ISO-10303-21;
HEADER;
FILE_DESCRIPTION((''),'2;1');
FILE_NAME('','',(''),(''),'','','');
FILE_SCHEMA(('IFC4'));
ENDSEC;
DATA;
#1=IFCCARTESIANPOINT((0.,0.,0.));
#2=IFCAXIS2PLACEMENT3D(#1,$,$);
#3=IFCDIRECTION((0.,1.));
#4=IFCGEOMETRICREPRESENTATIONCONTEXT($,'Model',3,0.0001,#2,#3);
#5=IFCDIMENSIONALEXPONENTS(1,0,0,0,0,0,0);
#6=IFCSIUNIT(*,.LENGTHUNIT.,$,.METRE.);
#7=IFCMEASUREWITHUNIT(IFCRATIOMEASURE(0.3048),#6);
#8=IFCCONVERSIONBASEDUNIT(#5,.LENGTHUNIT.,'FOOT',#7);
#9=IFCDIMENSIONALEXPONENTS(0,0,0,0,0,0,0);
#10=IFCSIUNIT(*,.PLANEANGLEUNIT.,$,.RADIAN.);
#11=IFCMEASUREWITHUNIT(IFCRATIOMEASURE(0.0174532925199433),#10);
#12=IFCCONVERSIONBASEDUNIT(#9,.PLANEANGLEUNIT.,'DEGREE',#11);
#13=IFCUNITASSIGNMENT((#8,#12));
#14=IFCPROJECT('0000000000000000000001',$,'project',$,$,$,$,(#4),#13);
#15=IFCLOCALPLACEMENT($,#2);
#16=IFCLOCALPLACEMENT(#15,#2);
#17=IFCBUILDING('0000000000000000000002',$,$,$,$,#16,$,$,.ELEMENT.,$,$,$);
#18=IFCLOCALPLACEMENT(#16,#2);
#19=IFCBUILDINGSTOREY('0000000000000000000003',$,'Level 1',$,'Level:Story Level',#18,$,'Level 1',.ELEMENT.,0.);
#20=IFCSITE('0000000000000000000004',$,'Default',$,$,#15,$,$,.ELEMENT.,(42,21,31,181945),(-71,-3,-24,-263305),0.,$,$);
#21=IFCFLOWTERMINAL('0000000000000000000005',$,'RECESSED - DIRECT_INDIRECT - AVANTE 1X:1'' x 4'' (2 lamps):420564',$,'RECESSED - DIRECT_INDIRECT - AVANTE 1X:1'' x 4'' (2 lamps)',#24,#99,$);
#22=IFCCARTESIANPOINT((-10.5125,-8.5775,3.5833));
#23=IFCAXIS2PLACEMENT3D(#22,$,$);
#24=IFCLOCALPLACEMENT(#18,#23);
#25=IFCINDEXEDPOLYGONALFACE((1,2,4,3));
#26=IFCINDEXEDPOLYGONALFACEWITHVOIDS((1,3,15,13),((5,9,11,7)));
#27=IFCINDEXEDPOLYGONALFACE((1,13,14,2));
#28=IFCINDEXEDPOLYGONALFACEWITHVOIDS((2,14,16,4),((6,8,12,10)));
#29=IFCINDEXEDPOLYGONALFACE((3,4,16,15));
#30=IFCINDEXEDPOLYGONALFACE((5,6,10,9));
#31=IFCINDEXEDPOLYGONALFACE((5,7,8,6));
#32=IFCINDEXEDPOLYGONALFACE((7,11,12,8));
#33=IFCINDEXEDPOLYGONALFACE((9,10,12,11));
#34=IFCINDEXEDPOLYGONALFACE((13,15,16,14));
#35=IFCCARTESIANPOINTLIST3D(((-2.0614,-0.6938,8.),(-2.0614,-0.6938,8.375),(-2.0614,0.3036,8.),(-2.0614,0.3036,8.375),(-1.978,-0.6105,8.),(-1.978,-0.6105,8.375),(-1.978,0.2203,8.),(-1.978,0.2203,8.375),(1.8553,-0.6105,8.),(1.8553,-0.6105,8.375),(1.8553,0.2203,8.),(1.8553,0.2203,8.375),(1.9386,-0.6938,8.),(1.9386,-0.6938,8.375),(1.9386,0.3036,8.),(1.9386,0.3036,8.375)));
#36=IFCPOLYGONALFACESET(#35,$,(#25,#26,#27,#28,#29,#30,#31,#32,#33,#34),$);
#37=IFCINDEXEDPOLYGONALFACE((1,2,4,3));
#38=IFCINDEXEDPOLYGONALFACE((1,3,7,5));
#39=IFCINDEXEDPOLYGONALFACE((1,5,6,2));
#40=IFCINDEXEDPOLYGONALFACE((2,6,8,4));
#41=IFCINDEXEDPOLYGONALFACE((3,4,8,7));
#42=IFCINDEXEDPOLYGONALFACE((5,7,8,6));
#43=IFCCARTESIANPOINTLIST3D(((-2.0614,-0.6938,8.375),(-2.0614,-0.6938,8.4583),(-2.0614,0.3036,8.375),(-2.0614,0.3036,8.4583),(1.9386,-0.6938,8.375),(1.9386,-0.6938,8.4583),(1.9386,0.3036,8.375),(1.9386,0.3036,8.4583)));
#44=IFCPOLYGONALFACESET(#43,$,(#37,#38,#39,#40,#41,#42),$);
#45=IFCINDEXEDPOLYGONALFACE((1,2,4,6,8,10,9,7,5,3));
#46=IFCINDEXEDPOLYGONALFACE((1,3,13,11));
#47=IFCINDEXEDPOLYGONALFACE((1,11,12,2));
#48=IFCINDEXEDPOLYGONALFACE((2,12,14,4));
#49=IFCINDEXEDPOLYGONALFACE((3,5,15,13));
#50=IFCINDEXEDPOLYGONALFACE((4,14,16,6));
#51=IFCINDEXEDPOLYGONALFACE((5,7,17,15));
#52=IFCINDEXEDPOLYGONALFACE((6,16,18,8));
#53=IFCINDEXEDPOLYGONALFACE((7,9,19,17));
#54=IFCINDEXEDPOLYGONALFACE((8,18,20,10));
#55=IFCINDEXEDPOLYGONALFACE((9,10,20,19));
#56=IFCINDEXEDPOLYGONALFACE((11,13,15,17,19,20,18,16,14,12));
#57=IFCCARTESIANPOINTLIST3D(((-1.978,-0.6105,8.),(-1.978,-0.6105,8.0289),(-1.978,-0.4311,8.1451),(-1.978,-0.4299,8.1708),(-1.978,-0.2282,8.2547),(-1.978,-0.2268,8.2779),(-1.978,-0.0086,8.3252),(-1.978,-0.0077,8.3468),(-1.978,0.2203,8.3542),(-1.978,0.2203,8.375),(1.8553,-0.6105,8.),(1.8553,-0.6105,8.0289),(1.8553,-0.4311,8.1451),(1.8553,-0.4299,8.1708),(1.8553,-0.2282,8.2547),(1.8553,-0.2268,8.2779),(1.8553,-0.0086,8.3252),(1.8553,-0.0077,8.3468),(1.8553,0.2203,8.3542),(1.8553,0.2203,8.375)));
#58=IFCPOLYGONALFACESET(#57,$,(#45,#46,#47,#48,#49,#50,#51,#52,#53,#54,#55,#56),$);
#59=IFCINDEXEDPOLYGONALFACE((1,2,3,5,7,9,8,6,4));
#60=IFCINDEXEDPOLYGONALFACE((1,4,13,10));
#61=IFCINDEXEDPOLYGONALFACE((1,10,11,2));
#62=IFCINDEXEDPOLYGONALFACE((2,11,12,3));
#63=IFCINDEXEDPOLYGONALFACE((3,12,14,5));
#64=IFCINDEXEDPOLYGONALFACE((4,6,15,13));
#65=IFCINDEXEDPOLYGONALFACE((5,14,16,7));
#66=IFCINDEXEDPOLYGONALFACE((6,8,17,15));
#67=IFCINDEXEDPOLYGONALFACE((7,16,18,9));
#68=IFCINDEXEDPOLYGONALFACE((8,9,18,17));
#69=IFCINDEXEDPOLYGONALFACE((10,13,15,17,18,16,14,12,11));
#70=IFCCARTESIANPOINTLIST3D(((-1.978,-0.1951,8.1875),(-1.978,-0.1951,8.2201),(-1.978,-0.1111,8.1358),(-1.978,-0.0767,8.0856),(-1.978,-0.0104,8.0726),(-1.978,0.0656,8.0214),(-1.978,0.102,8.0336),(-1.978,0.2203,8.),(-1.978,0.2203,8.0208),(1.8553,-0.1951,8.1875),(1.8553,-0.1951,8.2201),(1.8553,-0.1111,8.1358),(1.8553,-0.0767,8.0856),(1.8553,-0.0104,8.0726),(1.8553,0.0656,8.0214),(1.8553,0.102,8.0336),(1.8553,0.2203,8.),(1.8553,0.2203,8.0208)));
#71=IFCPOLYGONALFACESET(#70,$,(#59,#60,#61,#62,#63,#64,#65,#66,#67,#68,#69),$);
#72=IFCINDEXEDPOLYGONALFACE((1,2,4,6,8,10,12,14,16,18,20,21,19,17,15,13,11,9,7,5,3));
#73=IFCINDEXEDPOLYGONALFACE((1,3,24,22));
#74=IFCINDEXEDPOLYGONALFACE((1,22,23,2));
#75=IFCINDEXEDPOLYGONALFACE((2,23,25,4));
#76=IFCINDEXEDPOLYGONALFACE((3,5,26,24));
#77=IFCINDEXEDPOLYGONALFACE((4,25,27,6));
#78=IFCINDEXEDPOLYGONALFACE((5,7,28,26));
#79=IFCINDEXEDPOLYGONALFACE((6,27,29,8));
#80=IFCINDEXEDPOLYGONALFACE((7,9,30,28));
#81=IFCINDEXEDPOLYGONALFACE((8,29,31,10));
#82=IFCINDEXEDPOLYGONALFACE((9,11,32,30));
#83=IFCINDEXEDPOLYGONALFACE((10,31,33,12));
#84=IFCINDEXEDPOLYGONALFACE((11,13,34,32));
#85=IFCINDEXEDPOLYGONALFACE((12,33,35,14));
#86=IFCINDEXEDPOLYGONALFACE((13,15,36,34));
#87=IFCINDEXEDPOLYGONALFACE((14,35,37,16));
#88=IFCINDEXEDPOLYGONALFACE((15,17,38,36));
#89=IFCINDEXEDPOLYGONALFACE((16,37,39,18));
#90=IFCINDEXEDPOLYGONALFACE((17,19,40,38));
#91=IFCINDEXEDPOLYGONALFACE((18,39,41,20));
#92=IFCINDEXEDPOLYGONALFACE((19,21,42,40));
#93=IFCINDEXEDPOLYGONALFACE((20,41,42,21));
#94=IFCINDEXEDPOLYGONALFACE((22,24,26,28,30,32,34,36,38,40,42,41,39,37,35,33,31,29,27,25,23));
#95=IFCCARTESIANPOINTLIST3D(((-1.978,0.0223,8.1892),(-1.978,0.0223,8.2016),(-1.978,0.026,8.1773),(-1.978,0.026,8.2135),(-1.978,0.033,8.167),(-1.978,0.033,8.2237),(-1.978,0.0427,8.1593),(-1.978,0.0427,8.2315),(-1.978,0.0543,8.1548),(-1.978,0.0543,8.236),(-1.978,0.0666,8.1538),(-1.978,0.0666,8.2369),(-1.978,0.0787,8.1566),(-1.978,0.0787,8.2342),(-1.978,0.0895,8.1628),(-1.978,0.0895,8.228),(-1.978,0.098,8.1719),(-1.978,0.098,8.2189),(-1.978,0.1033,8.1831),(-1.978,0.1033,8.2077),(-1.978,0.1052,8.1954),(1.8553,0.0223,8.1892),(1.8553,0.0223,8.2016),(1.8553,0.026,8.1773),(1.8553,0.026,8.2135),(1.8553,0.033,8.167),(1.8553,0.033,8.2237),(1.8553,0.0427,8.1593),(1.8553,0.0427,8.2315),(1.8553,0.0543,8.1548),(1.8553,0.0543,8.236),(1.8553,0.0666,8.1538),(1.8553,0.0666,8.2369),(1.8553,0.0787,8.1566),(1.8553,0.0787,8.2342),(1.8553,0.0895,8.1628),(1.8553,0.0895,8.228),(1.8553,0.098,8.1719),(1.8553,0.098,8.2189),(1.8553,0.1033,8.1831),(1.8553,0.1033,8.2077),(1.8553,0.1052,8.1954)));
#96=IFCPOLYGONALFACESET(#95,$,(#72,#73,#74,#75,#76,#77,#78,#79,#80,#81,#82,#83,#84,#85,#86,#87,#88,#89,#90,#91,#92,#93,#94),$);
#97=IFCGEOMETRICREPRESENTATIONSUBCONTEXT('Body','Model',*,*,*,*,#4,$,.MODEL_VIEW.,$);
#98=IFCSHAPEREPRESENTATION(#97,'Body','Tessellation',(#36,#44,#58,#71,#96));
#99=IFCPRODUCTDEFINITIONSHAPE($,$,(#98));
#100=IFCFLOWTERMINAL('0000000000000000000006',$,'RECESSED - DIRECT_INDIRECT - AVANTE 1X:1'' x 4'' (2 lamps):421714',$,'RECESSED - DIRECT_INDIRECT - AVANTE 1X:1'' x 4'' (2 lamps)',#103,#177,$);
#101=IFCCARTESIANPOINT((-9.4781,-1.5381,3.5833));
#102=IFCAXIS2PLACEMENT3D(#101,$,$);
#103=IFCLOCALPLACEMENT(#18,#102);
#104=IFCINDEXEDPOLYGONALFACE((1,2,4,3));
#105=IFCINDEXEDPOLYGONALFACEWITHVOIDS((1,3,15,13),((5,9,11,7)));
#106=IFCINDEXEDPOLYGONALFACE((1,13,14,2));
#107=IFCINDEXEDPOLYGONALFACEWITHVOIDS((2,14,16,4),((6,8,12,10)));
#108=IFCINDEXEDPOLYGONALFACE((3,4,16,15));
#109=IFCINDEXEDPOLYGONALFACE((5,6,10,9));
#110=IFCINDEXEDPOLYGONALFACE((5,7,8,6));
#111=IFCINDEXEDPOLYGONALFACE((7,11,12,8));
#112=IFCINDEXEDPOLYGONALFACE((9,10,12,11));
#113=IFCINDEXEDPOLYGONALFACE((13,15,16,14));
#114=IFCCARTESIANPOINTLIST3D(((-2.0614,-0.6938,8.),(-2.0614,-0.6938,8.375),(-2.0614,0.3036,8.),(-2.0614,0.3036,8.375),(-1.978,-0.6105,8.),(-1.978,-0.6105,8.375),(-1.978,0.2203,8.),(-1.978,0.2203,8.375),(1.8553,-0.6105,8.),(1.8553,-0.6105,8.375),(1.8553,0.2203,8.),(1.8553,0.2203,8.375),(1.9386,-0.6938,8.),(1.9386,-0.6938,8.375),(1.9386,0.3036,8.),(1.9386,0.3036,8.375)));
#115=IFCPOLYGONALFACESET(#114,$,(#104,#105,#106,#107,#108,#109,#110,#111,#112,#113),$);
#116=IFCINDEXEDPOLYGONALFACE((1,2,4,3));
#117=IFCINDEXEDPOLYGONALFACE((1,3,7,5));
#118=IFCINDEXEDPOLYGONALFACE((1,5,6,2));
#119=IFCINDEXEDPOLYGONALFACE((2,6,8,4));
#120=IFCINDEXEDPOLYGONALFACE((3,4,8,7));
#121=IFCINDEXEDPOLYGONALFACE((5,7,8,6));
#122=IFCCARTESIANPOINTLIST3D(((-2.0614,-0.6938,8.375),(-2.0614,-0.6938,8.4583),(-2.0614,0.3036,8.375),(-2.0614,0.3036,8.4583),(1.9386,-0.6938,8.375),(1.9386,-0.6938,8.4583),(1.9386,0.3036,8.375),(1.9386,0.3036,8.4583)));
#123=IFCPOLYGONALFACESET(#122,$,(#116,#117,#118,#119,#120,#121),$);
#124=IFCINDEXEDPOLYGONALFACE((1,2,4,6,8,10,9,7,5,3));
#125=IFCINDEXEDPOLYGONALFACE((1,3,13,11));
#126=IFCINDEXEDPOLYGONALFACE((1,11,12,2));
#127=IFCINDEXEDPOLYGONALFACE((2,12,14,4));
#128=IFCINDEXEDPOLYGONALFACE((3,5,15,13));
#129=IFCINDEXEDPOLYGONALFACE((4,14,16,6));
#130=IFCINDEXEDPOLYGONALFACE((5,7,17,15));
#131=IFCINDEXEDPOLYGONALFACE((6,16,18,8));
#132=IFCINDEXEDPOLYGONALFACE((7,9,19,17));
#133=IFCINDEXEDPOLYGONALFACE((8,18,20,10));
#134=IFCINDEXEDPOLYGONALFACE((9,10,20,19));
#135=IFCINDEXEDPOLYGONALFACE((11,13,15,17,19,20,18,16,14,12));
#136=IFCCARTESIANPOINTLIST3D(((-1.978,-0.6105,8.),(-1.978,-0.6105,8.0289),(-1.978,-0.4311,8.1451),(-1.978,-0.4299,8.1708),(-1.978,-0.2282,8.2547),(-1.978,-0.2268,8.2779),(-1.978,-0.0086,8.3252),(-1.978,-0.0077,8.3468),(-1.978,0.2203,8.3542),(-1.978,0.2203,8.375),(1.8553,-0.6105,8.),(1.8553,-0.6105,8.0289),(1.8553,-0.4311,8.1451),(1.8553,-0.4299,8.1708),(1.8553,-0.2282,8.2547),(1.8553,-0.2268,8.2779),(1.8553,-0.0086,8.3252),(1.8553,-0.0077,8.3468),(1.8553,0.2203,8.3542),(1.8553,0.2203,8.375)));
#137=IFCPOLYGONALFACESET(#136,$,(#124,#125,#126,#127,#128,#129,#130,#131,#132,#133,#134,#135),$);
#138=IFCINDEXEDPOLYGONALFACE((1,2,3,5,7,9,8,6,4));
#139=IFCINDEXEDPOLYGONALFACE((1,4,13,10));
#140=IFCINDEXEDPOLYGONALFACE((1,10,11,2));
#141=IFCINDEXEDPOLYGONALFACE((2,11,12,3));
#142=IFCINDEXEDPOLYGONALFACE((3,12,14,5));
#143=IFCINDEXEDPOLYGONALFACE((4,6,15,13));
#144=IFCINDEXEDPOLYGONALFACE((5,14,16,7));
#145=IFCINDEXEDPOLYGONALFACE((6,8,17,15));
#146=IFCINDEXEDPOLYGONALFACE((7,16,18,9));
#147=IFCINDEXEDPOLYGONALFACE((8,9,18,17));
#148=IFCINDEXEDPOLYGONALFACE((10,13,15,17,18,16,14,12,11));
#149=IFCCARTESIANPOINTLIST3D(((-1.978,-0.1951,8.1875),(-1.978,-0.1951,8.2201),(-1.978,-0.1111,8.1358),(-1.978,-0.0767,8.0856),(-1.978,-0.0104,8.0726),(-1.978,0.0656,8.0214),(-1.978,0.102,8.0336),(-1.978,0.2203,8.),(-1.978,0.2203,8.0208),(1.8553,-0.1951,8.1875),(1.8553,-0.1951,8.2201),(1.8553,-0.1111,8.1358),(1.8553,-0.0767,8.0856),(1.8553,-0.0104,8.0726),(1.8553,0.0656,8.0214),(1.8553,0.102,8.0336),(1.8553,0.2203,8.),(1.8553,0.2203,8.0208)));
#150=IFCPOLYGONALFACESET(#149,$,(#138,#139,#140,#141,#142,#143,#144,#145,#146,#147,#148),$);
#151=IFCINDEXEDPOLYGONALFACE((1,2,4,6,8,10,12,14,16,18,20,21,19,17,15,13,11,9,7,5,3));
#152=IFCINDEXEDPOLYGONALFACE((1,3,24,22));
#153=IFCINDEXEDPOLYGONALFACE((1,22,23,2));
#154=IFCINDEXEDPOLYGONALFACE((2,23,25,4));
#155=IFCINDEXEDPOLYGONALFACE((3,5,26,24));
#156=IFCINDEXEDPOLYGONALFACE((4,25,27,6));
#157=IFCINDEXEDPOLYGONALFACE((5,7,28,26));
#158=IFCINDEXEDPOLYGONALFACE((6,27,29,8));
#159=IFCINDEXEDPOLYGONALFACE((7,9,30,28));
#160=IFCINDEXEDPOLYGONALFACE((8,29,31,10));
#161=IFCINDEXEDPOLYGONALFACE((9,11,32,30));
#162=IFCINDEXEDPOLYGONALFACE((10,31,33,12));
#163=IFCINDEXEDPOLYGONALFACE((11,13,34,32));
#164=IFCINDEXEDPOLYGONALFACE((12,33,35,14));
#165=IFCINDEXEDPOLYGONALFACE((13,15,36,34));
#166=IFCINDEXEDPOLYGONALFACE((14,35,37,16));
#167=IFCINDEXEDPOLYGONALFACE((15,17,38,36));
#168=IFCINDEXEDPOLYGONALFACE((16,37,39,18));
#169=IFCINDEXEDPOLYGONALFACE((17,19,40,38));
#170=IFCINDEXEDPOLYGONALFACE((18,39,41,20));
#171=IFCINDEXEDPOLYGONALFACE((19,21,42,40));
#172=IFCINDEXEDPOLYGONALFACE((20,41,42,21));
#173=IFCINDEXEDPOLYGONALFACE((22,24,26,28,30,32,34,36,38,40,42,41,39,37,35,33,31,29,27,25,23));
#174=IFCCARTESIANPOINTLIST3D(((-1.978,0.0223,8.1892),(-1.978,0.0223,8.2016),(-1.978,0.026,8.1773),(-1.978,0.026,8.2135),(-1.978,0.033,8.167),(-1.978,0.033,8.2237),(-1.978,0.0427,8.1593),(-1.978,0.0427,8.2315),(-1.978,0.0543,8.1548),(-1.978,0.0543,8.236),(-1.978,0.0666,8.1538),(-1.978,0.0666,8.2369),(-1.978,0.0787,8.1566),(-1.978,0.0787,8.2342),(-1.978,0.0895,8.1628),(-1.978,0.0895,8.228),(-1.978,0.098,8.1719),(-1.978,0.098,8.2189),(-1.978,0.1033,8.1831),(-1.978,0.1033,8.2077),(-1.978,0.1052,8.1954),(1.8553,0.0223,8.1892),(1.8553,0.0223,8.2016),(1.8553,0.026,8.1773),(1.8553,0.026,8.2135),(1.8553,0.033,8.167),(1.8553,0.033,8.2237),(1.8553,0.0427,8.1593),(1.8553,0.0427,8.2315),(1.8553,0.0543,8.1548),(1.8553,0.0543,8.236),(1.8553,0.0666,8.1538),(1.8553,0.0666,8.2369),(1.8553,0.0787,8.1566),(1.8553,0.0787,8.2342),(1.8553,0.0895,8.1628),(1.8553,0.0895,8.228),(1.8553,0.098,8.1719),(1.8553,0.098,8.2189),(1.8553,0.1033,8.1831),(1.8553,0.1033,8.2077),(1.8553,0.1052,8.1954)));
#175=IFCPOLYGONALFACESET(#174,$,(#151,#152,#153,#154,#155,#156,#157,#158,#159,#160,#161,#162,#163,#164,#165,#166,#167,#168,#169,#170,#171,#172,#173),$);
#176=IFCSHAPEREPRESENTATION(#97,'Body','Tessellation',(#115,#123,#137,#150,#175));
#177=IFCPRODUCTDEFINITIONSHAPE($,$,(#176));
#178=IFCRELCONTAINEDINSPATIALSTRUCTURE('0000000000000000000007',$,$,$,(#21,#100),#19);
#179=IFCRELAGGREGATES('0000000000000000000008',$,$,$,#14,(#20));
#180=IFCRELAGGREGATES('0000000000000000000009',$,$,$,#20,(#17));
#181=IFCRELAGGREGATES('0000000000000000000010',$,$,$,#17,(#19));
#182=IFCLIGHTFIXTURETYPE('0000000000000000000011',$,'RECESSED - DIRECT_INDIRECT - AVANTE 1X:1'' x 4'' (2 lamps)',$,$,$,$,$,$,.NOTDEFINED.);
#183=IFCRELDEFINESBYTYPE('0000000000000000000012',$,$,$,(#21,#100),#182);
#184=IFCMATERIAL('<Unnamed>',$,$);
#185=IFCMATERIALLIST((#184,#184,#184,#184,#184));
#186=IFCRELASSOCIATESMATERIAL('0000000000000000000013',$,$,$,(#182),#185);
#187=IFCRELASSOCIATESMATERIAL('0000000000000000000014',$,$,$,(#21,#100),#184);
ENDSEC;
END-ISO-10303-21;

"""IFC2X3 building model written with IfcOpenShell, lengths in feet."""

from ifc_helpers import new_model, entity, si_unit, converted_unit, direction, frame, frame_2d, origin, origin_2d_with_axis, place, context, subcontext, project, spatial, polyline, circle_curve, parameter, trimmed, segment, composite_curve, rectangle, circle, outline, extrude, source, transform, mapped, material, material_list, type_object, type_shapes, element, save


model = new_model("IFC2X3")

# Units and contexts
model_context = context("Model", 3, precision=0.0001, world=origin(), true_north=direction((0.0, 1.0)))
body_context = subcontext(model_context, "Body", "Model", "MODEL_VIEW")
ifc_project = project(units=[converted_unit("LENGTHUNIT", "FOOT", entity("IfcRatioMeasure", 0.3048), si_unit("LENGTHUNIT", "METRE"), dimensions=[1, 0, 0, 0, 0, 0, 0]), converted_unit("PLANEANGLEUNIT", "DEGREE", entity("IfcRatioMeasure", 0.0174532925199433), si_unit("PLANEANGLEUNIT", "RADIAN"), dimensions=[0, 0, 0, 0, 0, 0, 0])], contexts=[model_context])

# Site, building, storey
site_placement = place(None, origin())
site = spatial("IfcSite", under=ifc_project, at=site_placement, Name="Default", CompositionType="ELEMENT", RefLatitude=(42, 21, 31, 181945), RefLongitude=(-71, -3, -24, -263305), RefElevation=0.0)
building_placement = place(site_placement, origin())
building = spatial("IfcBuilding", under=site, at=building_placement, CompositionType="ELEMENT")
storey_placement = place(building_placement, origin())
storey = spatial("IfcBuildingStorey", under=building, at=storey_placement, Name="Level 1", ObjectType="Level:Story Level", LongName="Level 1", CompositionType="ELEMENT", Elevation=0.0)

# Flow terminals
ifc_material_1 = material(Name="<Unnamed>")
ifc_material_list_1 = material_list([ifc_material_1, ifc_material_1, ifc_material_1, ifc_material_1, ifc_material_1])
light_fixture_type = type_object("IfcLightFixtureType", Name="RECESSED - DIRECT_INDIRECT - AVANTE 1X:1' x 4' (2 lamps)", PredefinedType="NOTDEFINED", material=ifc_material_list_1)
shared_shape_1 = source(origin(), body_context, "Body", "SweptSolid", [
    extrude(outline(polyline([(-2.0, -0.4987), (2.0, -0.4987), (2.0, 0.4987), (-2.0, 0.4987), (-2.0, -0.4987)]), holes=[polyline([(-1.9167, -0.4154), (-1.9167, 0.4154), (1.9167, 0.4154), (1.9167, -0.4154), (-1.9167, -0.4154)])]), frame((-0.0614, -0.1951, 8.0), z_axis=(0.0, 0.0, 1.0), x_axis=(-1.0, 0.0, 0.0)), (0.0, 0.0, 1.0), 0.375),
    extrude(rectangle(XDim=4.0, YDim=0.9974, at=origin_2d_with_axis()), frame((-0.0614, -0.1951, 8.375), z_axis=(0.0, 0.0, 1.0), x_axis=(-1.0, 0.0, 0.0)), (0.0, 0.0, 1.0), 0.0833),
    extrude(outline(composite_curve([segment(trimmed(circle_curve(frame_2d((-1.0846, 0.4571), x_axis=(-1.0, 0.0)), 1.25), [parameter(135.734122)], [parameter(178.085644)], True, "PARAMETER"), False, "CONTINUOUS"), segment(polyline([(-0.1895, -0.4154), (-0.1606, -0.4154)]), True, "CONTINUOUS"), segment(trimmed(circle_curve(frame_2d((-1.0846, 0.4571), x_axis=(-1.0, 0.0)), 1.2708), [parameter(136.642648)], [parameter(178.117038)], True, "PARAMETER"), True, "CONTINUOUS"), segment(polyline([(0.1855, 0.4154), (0.1647, 0.4154)]), True, "CONTINUOUS")], self_intersect=False)), frame((-1.978, -0.1951, 8.1895), z_axis=(-1.0, 0.0, 0.0), x_axis=(0.0, 0.0, 1.0)), (0.0, 0.0, -1.0), 3.8333),
    extrude(outline(composite_curve([segment(polyline([(0.0863, -0.2077), (0.1071, -0.2077)]), True, "CONTINUOUS"), segment(trimmed(circle_curve(frame_2d((-0.4397, -0.2045), x_axis=(1.0, 0.0)), 0.5468), [parameter(359.668292)], [parameter(48.921556)], True, "PARAMETER"), True, "CONTINUOUS"), segment(polyline([(-0.0804, 0.2077), (-0.113, 0.2077)]), True, "CONTINUOUS"), segment(trimmed(circle_curve(frame_2d((-0.4397, -0.2045), x_axis=(1.0, 0.0)), 0.526), [parameter(359.655153)], [parameter(51.59762)], True, "PARAMETER"), False, "CONTINUOUS")], self_intersect=False)), frame((-1.978, 0.0126, 8.1071), z_axis=(-1.0, 0.0, 0.0), x_axis=(0.0, 0.0, -1.0)), (0.0, 0.0, -1.0), 3.8333),
    extrude(circle(Radius=0.0417, at=origin_2d_with_axis()), frame((-1.978, 0.0635, 8.1954), z_axis=(1.0, 0.0, 0.0), x_axis=(0.0, 1.0, 0.0)), (0.0, 0.0, 1.0), 3.8333),
])
type_shapes(light_fixture_type, [shared_shape_1])
for number, where, name in (
    (1, (-10.5125, -8.5775, 3.5833), "RECESSED - DIRECT_INDIRECT - AVANTE 1X:1' x 4' (2 lamps):420564"),
    (2, (-9.4781, -1.5381, 3.5833), "RECESSED - DIRECT_INDIRECT - AVANTE 1X:1' x 4' (2 lamps):421714"),
):
    element("IfcFlowTerminal", number, at=place(storey_placement, frame(where)), inside=storey, type_object=light_fixture_type, material=ifc_material_1, Name=name, ObjectType="RECESSED - DIRECT_INDIRECT - AVANTE 1X:1' x 4' (2 lamps)", context=body_context, shape_type="MappedRepresentation", body=[
        mapped(shared_shape_1, transform((0.0, 0.0, 0.0), scale=1.0)),
    ])

save(model, "model.ifc")
